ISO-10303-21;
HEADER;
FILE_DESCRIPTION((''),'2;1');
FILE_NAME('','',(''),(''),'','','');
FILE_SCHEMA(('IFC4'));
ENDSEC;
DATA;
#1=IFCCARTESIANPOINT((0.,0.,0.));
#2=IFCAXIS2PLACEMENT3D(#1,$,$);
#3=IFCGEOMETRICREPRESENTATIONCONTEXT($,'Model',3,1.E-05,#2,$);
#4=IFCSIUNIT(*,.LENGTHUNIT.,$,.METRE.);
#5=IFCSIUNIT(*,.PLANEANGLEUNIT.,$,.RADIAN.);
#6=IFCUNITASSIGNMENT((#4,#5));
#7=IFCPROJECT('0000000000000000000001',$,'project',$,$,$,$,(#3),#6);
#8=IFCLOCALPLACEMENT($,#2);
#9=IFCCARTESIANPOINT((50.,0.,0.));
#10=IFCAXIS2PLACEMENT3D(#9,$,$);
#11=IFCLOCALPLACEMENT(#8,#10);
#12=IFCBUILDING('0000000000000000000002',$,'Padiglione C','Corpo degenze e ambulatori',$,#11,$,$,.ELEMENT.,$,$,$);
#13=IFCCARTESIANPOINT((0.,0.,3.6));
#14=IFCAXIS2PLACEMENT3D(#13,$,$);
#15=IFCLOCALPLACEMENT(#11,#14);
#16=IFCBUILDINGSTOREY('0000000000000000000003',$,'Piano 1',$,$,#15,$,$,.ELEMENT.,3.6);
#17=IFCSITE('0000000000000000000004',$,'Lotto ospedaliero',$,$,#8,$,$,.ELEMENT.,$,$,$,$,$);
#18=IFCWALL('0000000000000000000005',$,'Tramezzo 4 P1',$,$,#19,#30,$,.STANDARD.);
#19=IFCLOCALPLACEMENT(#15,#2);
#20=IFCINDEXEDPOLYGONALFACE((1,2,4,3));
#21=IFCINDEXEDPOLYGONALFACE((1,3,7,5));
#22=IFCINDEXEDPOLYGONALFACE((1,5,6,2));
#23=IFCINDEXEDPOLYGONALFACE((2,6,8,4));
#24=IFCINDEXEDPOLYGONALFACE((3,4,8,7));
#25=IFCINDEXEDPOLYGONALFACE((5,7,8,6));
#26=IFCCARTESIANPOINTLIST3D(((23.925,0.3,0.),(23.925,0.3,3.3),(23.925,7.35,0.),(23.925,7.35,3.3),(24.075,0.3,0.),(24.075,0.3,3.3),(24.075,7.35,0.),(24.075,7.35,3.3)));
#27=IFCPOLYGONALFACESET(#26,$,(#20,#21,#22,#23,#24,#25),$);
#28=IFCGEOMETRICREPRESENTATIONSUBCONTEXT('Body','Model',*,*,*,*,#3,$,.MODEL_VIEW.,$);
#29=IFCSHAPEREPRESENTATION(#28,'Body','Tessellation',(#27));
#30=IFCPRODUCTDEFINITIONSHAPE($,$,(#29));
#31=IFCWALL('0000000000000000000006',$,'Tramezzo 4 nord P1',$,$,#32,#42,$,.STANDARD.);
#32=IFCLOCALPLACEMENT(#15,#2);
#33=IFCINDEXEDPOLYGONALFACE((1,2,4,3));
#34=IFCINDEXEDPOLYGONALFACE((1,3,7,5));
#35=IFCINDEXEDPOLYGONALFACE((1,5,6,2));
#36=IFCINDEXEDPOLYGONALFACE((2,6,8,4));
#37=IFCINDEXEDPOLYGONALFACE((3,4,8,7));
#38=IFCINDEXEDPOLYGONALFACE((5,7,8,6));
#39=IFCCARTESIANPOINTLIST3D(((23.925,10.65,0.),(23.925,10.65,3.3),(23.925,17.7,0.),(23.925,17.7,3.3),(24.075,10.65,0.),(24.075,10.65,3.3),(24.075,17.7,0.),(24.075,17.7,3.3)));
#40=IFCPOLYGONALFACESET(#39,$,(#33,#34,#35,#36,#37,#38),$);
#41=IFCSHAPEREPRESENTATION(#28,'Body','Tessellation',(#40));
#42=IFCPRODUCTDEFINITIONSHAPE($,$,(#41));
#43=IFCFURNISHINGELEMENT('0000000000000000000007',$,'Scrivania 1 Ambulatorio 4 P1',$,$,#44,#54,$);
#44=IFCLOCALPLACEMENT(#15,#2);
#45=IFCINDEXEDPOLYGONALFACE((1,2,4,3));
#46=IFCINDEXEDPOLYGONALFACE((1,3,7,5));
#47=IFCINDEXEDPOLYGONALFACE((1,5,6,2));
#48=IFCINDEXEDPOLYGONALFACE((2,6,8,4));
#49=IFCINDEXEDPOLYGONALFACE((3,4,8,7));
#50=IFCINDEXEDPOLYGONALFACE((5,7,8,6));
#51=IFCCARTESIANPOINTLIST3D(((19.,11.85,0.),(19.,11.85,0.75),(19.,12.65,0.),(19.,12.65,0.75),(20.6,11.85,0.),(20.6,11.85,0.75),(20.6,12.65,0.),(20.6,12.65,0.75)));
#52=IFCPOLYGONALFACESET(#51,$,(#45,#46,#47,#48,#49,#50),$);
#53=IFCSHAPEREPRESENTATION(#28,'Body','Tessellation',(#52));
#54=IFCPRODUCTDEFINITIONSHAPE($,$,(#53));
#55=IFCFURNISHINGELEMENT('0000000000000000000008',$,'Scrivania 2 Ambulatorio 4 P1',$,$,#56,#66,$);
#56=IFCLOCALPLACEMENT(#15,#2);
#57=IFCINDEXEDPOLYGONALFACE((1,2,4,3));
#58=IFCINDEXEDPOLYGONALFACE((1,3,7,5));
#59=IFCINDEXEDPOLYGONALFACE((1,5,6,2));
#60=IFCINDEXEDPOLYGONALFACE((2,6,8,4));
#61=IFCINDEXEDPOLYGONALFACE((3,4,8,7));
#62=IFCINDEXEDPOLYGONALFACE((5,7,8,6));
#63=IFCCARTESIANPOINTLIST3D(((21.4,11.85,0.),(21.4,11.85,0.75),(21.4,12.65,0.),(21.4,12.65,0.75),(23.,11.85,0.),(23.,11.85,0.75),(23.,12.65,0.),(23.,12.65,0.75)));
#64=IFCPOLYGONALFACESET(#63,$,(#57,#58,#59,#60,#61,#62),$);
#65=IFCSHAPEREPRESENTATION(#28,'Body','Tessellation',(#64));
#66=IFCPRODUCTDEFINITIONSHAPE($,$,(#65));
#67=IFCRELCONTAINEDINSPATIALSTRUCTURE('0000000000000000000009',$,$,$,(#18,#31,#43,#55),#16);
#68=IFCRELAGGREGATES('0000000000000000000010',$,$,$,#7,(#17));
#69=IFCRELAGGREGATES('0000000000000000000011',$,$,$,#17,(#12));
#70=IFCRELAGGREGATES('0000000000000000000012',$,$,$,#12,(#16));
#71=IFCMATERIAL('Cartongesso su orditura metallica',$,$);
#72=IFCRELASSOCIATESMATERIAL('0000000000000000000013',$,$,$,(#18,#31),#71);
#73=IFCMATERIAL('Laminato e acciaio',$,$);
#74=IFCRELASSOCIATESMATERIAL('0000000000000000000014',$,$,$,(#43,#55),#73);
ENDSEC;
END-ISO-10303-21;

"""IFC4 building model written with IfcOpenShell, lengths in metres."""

from ifc_helpers import new_model, si_unit, frame, frame_2d, origin, place, context, subcontext, project, spatial, rectangle, extrude, material, element, save


model = new_model("IFC4")

# Units and contexts
model_context = context("Model", 3, precision=1e-05, world=origin())
body_context = subcontext(model_context, "Body", "Model", "MODEL_VIEW")
ifc_project = project(units=[si_unit("LENGTHUNIT", "METRE"), si_unit("PLANEANGLEUNIT", "RADIAN")], contexts=[model_context])

# Site, building, storey
site_placement = place(None, origin())
site = spatial("IfcSite", under=ifc_project, at=site_placement, Name="Lotto ospedaliero", CompositionType="ELEMENT")
building_placement = place(site_placement, frame((50.0, 0.0, 0.0)))
building = spatial("IfcBuilding", under=site, at=building_placement, Name="Padiglione C", Description="Corpo degenze e ambulatori", CompositionType="ELEMENT")
storey_placement = place(building_placement, frame((0.0, 0.0, 3.6)))
storey = spatial("IfcBuildingStorey", under=building, at=storey_placement, Name="Piano 1", CompositionType="ELEMENT", Elevation=3.6)

# Walls
ifc_material_1 = material(Name="Cartongesso su orditura metallica")
for number, where, name in (
    (1, (23.925, 0.3, 0.0), "Tramezzo 4 P1"),
    (2, (23.925, 10.65, 0.0), "Tramezzo 4 nord P1"),
):
    element("IfcWall", number, at=place(storey_placement, frame(where)), inside=storey, material=ifc_material_1, Name=name, PredefinedType="STANDARD", context=body_context, shape_type="SweptSolid", body=[
        extrude(rectangle(XDim=0.15, YDim=7.05, at=frame_2d((0.075, 3.525))), origin(), (0.0, 0.0, 1.0), 3.3),
    ])

# Furnishing elements
ifc_material_2 = material(Name="Laminato e acciaio")
for number, where, name in (
    (3, (19.0, 11.85, 0.0), "Scrivania 1 Ambulatorio 4 P1"),
    (4, (21.4, 11.85, 0.0), "Scrivania 2 Ambulatorio 4 P1"),
):
    element("IfcFurnishingElement", number, at=place(storey_placement, frame(where)), inside=storey, material=ifc_material_2, Name=name, context=body_context, shape_type="SweptSolid", body=[
        extrude(rectangle(XDim=1.6, YDim=0.8, at=frame_2d((0.8, 0.4))), origin(), (0.0, 0.0, 1.0), 0.75),
    ])

save(model, "model.ifc")
